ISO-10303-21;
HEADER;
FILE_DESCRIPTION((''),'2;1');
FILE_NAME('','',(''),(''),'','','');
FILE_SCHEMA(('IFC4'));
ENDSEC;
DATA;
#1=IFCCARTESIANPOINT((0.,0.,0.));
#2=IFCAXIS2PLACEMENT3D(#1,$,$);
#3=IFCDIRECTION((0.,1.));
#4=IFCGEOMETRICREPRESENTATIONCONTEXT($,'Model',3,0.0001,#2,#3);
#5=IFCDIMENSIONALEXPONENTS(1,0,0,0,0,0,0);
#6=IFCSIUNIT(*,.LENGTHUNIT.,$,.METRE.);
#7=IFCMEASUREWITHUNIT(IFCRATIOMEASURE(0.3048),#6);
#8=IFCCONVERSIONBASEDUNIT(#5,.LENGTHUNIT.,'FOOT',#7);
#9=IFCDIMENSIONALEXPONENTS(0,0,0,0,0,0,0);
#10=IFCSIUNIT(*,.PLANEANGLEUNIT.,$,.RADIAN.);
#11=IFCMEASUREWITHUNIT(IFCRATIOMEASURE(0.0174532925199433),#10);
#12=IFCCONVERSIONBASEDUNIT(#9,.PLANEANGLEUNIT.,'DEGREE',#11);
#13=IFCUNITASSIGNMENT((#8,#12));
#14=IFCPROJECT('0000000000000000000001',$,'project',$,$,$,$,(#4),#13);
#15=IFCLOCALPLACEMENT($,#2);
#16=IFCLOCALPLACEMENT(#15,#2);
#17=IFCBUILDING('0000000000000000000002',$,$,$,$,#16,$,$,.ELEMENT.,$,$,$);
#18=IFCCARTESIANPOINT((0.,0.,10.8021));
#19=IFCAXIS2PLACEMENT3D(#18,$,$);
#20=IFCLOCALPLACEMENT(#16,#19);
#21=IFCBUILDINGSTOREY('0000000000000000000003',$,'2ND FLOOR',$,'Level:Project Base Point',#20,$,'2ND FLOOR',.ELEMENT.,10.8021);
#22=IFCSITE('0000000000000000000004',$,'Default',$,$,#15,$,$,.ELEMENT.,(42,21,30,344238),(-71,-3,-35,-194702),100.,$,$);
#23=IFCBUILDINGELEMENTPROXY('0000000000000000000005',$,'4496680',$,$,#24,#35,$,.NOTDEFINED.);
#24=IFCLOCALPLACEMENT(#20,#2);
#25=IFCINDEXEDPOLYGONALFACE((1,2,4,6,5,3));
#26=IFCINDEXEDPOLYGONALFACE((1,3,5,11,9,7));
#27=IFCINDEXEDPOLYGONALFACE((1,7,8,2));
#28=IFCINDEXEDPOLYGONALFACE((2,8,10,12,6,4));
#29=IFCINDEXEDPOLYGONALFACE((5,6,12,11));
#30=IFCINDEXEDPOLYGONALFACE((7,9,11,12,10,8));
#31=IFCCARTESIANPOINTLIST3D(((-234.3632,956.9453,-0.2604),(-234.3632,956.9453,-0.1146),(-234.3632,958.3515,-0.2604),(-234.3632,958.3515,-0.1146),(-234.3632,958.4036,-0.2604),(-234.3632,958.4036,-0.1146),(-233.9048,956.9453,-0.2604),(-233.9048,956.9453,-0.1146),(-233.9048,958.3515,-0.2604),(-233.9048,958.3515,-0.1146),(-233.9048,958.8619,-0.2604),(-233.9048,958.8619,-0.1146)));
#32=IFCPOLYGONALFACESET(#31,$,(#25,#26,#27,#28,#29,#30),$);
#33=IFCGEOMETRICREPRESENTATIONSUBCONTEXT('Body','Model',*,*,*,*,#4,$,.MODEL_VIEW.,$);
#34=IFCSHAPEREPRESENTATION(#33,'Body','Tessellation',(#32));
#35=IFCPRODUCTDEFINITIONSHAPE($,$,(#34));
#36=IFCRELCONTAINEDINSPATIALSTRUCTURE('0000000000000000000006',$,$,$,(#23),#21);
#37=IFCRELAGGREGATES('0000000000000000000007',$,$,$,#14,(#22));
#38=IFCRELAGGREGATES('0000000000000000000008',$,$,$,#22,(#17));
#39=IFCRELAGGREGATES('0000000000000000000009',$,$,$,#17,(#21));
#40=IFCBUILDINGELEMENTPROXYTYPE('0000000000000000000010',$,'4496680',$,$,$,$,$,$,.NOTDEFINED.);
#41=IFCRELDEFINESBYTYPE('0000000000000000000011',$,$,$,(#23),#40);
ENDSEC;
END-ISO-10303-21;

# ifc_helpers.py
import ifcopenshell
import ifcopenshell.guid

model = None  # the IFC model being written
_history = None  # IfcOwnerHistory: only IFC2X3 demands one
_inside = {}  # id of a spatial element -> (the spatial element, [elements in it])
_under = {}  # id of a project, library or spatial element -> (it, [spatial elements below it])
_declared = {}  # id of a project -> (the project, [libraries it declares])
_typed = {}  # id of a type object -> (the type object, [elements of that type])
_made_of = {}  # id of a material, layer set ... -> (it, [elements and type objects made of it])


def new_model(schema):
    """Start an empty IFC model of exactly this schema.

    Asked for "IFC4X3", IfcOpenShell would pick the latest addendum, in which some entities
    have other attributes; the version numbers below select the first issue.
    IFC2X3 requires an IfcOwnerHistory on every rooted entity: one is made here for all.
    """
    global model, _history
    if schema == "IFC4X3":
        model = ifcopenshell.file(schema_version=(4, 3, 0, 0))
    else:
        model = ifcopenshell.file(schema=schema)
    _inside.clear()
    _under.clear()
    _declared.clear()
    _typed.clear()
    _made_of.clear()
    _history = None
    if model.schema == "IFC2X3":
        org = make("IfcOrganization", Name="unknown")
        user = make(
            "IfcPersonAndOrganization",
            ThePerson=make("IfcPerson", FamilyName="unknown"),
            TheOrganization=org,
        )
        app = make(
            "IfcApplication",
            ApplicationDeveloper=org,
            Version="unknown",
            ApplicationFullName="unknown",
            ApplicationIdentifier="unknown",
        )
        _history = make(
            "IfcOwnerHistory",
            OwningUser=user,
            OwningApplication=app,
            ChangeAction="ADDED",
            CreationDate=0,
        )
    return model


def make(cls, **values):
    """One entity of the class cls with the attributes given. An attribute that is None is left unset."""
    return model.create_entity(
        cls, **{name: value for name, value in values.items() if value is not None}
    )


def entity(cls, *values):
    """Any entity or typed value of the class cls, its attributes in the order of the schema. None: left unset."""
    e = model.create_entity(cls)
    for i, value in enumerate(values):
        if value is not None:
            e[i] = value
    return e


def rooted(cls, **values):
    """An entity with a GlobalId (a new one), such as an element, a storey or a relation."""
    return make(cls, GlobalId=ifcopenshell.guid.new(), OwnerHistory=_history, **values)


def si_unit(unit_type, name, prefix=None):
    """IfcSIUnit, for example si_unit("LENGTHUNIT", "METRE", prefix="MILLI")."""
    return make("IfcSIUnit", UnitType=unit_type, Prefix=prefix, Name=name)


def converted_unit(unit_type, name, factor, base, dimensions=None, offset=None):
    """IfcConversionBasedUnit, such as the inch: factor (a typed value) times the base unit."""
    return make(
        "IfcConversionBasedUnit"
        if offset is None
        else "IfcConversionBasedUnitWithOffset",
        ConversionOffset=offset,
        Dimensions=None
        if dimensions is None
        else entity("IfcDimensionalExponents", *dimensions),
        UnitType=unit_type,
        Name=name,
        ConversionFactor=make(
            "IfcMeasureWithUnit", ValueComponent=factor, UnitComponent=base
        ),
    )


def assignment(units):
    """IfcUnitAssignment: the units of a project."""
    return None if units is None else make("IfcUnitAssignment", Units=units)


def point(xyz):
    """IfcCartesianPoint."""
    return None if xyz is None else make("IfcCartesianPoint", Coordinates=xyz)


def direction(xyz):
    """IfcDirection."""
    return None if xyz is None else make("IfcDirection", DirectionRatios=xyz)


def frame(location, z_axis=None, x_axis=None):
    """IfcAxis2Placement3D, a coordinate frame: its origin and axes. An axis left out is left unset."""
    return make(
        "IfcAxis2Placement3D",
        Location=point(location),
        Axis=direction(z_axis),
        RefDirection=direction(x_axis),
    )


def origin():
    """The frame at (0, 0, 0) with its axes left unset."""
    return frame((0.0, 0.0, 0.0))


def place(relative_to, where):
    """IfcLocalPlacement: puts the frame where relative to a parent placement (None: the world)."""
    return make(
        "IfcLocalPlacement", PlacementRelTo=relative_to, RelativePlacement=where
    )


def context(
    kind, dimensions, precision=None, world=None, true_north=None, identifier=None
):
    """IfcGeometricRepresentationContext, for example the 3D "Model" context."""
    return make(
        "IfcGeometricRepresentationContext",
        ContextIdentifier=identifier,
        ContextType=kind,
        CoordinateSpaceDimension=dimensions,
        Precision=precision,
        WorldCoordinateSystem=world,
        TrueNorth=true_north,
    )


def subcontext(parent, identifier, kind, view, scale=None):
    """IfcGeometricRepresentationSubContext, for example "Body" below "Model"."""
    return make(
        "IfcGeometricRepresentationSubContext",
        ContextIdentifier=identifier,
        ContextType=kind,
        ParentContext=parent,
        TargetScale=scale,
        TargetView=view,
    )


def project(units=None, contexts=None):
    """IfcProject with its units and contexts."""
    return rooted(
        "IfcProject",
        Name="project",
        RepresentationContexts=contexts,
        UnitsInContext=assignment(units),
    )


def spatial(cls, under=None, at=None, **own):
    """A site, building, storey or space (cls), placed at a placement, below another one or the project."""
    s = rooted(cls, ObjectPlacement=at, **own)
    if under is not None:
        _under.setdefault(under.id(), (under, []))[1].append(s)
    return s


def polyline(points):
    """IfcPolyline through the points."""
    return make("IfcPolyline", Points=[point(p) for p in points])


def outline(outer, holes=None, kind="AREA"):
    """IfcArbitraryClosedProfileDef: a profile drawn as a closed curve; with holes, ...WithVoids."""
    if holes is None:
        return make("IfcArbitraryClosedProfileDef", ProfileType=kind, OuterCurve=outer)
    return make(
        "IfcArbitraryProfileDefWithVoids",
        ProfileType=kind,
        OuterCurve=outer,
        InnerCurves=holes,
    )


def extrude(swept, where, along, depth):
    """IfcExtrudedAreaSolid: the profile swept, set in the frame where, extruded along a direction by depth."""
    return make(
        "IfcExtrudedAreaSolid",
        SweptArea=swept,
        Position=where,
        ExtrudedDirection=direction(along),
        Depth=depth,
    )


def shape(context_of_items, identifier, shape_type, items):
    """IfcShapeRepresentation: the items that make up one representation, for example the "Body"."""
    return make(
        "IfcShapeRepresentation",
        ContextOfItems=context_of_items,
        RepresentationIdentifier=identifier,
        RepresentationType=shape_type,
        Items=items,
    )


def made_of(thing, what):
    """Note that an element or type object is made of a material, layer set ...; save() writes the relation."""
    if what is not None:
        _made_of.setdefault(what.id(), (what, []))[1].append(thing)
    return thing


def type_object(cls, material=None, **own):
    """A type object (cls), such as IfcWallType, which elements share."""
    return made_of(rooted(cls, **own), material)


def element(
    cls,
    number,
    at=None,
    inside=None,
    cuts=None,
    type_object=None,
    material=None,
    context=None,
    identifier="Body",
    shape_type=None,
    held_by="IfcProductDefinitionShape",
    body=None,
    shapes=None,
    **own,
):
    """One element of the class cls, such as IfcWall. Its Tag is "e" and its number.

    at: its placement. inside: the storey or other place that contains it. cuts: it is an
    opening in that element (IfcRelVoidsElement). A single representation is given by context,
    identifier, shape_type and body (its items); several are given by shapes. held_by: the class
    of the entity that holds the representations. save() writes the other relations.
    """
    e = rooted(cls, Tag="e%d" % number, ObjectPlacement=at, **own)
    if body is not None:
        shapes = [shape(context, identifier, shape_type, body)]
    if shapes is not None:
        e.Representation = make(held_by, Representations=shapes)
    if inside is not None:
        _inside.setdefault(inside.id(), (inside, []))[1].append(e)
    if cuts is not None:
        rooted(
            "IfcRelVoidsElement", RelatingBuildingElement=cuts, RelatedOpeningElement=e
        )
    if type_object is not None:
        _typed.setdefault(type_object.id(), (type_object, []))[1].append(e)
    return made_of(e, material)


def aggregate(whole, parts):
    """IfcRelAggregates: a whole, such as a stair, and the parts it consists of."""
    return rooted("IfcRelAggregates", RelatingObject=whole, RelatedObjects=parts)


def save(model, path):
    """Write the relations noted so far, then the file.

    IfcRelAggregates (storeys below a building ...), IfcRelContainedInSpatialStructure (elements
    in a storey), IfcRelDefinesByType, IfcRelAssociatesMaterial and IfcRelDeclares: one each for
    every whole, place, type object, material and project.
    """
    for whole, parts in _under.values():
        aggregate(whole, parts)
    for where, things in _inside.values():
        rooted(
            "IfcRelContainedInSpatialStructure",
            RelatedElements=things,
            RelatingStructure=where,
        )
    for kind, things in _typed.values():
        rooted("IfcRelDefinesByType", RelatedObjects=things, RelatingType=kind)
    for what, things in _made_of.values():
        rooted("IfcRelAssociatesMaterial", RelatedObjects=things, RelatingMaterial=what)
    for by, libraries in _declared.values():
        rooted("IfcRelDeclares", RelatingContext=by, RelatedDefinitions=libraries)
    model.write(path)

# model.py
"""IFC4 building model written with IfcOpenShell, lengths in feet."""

from ifc_helpers import new_model, entity, si_unit, converted_unit, direction, frame, origin, place, context, subcontext, project, spatial, polyline, outline, extrude, type_object, element, save


model = new_model("IFC4")

# Units and contexts
model_context = context("Model", 3, precision=0.0001, world=origin(), true_north=direction((0.0, 1.0)))
body_context = subcontext(model_context, "Body", "Model", "MODEL_VIEW")
ifc_project = project(units=[converted_unit("LENGTHUNIT", "FOOT", entity("IfcRatioMeasure", 0.3048), si_unit("LENGTHUNIT", "METRE"), dimensions=[1, 0, 0, 0, 0, 0, 0]), converted_unit("PLANEANGLEUNIT", "DEGREE", entity("IfcRatioMeasure", 0.0174532925199433), si_unit("PLANEANGLEUNIT", "RADIAN"), dimensions=[0, 0, 0, 0, 0, 0, 0])], contexts=[model_context])

# Site, building, storey
site_placement = place(None, origin())
site = spatial("IfcSite", under=ifc_project, at=site_placement, Name="Default", CompositionType="ELEMENT", RefLatitude=(42, 21, 30, 344238), RefLongitude=(-71, -3, -35, -194702), RefElevation=100.0)
building_placement = place(site_placement, origin())
building = spatial("IfcBuilding", under=site, at=building_placement, CompositionType="ELEMENT")
storey_placement = place(building_placement, frame((0.0, 0.0, 10.8021)))
storey = spatial("IfcBuildingStorey", under=building, at=storey_placement, Name="2ND FLOOR", ObjectType="Level:Project Base Point", LongName="2ND FLOOR", CompositionType="ELEMENT", Elevation=10.8021)

# Building element proxy
building_element_proxy_type_1 = type_object("IfcBuildingElementProxyType", Name="4496680", PredefinedType="NOTDEFINED")
proxy_1_placement = place(storey_placement, frame((-234.3632, 956.9453, -0.2604)))
element("IfcBuildingElementProxy", 1, at=proxy_1_placement, inside=storey, type_object=building_element_proxy_type_1, Name="4496680", PredefinedType="NOTDEFINED", context=body_context, shape_type="SweptSolid", body=[
    extrude(outline(polyline([(-0.4271, -0.2292), (-0.375, -0.2292), (1.0312, -0.2292), (1.0312, 0.2292), (-0.375, 0.2292), (-0.8854, 0.2292), (-0.4271, -0.2292)])), frame((0.2292, 1.0312, 0.0), z_axis=(0.0, 0.0, 1.0), x_axis=(0.0, -1.0, 0.0)), (0.0, 0.0, 1.0), 0.1458),
])

save(model, "model.ifc")
